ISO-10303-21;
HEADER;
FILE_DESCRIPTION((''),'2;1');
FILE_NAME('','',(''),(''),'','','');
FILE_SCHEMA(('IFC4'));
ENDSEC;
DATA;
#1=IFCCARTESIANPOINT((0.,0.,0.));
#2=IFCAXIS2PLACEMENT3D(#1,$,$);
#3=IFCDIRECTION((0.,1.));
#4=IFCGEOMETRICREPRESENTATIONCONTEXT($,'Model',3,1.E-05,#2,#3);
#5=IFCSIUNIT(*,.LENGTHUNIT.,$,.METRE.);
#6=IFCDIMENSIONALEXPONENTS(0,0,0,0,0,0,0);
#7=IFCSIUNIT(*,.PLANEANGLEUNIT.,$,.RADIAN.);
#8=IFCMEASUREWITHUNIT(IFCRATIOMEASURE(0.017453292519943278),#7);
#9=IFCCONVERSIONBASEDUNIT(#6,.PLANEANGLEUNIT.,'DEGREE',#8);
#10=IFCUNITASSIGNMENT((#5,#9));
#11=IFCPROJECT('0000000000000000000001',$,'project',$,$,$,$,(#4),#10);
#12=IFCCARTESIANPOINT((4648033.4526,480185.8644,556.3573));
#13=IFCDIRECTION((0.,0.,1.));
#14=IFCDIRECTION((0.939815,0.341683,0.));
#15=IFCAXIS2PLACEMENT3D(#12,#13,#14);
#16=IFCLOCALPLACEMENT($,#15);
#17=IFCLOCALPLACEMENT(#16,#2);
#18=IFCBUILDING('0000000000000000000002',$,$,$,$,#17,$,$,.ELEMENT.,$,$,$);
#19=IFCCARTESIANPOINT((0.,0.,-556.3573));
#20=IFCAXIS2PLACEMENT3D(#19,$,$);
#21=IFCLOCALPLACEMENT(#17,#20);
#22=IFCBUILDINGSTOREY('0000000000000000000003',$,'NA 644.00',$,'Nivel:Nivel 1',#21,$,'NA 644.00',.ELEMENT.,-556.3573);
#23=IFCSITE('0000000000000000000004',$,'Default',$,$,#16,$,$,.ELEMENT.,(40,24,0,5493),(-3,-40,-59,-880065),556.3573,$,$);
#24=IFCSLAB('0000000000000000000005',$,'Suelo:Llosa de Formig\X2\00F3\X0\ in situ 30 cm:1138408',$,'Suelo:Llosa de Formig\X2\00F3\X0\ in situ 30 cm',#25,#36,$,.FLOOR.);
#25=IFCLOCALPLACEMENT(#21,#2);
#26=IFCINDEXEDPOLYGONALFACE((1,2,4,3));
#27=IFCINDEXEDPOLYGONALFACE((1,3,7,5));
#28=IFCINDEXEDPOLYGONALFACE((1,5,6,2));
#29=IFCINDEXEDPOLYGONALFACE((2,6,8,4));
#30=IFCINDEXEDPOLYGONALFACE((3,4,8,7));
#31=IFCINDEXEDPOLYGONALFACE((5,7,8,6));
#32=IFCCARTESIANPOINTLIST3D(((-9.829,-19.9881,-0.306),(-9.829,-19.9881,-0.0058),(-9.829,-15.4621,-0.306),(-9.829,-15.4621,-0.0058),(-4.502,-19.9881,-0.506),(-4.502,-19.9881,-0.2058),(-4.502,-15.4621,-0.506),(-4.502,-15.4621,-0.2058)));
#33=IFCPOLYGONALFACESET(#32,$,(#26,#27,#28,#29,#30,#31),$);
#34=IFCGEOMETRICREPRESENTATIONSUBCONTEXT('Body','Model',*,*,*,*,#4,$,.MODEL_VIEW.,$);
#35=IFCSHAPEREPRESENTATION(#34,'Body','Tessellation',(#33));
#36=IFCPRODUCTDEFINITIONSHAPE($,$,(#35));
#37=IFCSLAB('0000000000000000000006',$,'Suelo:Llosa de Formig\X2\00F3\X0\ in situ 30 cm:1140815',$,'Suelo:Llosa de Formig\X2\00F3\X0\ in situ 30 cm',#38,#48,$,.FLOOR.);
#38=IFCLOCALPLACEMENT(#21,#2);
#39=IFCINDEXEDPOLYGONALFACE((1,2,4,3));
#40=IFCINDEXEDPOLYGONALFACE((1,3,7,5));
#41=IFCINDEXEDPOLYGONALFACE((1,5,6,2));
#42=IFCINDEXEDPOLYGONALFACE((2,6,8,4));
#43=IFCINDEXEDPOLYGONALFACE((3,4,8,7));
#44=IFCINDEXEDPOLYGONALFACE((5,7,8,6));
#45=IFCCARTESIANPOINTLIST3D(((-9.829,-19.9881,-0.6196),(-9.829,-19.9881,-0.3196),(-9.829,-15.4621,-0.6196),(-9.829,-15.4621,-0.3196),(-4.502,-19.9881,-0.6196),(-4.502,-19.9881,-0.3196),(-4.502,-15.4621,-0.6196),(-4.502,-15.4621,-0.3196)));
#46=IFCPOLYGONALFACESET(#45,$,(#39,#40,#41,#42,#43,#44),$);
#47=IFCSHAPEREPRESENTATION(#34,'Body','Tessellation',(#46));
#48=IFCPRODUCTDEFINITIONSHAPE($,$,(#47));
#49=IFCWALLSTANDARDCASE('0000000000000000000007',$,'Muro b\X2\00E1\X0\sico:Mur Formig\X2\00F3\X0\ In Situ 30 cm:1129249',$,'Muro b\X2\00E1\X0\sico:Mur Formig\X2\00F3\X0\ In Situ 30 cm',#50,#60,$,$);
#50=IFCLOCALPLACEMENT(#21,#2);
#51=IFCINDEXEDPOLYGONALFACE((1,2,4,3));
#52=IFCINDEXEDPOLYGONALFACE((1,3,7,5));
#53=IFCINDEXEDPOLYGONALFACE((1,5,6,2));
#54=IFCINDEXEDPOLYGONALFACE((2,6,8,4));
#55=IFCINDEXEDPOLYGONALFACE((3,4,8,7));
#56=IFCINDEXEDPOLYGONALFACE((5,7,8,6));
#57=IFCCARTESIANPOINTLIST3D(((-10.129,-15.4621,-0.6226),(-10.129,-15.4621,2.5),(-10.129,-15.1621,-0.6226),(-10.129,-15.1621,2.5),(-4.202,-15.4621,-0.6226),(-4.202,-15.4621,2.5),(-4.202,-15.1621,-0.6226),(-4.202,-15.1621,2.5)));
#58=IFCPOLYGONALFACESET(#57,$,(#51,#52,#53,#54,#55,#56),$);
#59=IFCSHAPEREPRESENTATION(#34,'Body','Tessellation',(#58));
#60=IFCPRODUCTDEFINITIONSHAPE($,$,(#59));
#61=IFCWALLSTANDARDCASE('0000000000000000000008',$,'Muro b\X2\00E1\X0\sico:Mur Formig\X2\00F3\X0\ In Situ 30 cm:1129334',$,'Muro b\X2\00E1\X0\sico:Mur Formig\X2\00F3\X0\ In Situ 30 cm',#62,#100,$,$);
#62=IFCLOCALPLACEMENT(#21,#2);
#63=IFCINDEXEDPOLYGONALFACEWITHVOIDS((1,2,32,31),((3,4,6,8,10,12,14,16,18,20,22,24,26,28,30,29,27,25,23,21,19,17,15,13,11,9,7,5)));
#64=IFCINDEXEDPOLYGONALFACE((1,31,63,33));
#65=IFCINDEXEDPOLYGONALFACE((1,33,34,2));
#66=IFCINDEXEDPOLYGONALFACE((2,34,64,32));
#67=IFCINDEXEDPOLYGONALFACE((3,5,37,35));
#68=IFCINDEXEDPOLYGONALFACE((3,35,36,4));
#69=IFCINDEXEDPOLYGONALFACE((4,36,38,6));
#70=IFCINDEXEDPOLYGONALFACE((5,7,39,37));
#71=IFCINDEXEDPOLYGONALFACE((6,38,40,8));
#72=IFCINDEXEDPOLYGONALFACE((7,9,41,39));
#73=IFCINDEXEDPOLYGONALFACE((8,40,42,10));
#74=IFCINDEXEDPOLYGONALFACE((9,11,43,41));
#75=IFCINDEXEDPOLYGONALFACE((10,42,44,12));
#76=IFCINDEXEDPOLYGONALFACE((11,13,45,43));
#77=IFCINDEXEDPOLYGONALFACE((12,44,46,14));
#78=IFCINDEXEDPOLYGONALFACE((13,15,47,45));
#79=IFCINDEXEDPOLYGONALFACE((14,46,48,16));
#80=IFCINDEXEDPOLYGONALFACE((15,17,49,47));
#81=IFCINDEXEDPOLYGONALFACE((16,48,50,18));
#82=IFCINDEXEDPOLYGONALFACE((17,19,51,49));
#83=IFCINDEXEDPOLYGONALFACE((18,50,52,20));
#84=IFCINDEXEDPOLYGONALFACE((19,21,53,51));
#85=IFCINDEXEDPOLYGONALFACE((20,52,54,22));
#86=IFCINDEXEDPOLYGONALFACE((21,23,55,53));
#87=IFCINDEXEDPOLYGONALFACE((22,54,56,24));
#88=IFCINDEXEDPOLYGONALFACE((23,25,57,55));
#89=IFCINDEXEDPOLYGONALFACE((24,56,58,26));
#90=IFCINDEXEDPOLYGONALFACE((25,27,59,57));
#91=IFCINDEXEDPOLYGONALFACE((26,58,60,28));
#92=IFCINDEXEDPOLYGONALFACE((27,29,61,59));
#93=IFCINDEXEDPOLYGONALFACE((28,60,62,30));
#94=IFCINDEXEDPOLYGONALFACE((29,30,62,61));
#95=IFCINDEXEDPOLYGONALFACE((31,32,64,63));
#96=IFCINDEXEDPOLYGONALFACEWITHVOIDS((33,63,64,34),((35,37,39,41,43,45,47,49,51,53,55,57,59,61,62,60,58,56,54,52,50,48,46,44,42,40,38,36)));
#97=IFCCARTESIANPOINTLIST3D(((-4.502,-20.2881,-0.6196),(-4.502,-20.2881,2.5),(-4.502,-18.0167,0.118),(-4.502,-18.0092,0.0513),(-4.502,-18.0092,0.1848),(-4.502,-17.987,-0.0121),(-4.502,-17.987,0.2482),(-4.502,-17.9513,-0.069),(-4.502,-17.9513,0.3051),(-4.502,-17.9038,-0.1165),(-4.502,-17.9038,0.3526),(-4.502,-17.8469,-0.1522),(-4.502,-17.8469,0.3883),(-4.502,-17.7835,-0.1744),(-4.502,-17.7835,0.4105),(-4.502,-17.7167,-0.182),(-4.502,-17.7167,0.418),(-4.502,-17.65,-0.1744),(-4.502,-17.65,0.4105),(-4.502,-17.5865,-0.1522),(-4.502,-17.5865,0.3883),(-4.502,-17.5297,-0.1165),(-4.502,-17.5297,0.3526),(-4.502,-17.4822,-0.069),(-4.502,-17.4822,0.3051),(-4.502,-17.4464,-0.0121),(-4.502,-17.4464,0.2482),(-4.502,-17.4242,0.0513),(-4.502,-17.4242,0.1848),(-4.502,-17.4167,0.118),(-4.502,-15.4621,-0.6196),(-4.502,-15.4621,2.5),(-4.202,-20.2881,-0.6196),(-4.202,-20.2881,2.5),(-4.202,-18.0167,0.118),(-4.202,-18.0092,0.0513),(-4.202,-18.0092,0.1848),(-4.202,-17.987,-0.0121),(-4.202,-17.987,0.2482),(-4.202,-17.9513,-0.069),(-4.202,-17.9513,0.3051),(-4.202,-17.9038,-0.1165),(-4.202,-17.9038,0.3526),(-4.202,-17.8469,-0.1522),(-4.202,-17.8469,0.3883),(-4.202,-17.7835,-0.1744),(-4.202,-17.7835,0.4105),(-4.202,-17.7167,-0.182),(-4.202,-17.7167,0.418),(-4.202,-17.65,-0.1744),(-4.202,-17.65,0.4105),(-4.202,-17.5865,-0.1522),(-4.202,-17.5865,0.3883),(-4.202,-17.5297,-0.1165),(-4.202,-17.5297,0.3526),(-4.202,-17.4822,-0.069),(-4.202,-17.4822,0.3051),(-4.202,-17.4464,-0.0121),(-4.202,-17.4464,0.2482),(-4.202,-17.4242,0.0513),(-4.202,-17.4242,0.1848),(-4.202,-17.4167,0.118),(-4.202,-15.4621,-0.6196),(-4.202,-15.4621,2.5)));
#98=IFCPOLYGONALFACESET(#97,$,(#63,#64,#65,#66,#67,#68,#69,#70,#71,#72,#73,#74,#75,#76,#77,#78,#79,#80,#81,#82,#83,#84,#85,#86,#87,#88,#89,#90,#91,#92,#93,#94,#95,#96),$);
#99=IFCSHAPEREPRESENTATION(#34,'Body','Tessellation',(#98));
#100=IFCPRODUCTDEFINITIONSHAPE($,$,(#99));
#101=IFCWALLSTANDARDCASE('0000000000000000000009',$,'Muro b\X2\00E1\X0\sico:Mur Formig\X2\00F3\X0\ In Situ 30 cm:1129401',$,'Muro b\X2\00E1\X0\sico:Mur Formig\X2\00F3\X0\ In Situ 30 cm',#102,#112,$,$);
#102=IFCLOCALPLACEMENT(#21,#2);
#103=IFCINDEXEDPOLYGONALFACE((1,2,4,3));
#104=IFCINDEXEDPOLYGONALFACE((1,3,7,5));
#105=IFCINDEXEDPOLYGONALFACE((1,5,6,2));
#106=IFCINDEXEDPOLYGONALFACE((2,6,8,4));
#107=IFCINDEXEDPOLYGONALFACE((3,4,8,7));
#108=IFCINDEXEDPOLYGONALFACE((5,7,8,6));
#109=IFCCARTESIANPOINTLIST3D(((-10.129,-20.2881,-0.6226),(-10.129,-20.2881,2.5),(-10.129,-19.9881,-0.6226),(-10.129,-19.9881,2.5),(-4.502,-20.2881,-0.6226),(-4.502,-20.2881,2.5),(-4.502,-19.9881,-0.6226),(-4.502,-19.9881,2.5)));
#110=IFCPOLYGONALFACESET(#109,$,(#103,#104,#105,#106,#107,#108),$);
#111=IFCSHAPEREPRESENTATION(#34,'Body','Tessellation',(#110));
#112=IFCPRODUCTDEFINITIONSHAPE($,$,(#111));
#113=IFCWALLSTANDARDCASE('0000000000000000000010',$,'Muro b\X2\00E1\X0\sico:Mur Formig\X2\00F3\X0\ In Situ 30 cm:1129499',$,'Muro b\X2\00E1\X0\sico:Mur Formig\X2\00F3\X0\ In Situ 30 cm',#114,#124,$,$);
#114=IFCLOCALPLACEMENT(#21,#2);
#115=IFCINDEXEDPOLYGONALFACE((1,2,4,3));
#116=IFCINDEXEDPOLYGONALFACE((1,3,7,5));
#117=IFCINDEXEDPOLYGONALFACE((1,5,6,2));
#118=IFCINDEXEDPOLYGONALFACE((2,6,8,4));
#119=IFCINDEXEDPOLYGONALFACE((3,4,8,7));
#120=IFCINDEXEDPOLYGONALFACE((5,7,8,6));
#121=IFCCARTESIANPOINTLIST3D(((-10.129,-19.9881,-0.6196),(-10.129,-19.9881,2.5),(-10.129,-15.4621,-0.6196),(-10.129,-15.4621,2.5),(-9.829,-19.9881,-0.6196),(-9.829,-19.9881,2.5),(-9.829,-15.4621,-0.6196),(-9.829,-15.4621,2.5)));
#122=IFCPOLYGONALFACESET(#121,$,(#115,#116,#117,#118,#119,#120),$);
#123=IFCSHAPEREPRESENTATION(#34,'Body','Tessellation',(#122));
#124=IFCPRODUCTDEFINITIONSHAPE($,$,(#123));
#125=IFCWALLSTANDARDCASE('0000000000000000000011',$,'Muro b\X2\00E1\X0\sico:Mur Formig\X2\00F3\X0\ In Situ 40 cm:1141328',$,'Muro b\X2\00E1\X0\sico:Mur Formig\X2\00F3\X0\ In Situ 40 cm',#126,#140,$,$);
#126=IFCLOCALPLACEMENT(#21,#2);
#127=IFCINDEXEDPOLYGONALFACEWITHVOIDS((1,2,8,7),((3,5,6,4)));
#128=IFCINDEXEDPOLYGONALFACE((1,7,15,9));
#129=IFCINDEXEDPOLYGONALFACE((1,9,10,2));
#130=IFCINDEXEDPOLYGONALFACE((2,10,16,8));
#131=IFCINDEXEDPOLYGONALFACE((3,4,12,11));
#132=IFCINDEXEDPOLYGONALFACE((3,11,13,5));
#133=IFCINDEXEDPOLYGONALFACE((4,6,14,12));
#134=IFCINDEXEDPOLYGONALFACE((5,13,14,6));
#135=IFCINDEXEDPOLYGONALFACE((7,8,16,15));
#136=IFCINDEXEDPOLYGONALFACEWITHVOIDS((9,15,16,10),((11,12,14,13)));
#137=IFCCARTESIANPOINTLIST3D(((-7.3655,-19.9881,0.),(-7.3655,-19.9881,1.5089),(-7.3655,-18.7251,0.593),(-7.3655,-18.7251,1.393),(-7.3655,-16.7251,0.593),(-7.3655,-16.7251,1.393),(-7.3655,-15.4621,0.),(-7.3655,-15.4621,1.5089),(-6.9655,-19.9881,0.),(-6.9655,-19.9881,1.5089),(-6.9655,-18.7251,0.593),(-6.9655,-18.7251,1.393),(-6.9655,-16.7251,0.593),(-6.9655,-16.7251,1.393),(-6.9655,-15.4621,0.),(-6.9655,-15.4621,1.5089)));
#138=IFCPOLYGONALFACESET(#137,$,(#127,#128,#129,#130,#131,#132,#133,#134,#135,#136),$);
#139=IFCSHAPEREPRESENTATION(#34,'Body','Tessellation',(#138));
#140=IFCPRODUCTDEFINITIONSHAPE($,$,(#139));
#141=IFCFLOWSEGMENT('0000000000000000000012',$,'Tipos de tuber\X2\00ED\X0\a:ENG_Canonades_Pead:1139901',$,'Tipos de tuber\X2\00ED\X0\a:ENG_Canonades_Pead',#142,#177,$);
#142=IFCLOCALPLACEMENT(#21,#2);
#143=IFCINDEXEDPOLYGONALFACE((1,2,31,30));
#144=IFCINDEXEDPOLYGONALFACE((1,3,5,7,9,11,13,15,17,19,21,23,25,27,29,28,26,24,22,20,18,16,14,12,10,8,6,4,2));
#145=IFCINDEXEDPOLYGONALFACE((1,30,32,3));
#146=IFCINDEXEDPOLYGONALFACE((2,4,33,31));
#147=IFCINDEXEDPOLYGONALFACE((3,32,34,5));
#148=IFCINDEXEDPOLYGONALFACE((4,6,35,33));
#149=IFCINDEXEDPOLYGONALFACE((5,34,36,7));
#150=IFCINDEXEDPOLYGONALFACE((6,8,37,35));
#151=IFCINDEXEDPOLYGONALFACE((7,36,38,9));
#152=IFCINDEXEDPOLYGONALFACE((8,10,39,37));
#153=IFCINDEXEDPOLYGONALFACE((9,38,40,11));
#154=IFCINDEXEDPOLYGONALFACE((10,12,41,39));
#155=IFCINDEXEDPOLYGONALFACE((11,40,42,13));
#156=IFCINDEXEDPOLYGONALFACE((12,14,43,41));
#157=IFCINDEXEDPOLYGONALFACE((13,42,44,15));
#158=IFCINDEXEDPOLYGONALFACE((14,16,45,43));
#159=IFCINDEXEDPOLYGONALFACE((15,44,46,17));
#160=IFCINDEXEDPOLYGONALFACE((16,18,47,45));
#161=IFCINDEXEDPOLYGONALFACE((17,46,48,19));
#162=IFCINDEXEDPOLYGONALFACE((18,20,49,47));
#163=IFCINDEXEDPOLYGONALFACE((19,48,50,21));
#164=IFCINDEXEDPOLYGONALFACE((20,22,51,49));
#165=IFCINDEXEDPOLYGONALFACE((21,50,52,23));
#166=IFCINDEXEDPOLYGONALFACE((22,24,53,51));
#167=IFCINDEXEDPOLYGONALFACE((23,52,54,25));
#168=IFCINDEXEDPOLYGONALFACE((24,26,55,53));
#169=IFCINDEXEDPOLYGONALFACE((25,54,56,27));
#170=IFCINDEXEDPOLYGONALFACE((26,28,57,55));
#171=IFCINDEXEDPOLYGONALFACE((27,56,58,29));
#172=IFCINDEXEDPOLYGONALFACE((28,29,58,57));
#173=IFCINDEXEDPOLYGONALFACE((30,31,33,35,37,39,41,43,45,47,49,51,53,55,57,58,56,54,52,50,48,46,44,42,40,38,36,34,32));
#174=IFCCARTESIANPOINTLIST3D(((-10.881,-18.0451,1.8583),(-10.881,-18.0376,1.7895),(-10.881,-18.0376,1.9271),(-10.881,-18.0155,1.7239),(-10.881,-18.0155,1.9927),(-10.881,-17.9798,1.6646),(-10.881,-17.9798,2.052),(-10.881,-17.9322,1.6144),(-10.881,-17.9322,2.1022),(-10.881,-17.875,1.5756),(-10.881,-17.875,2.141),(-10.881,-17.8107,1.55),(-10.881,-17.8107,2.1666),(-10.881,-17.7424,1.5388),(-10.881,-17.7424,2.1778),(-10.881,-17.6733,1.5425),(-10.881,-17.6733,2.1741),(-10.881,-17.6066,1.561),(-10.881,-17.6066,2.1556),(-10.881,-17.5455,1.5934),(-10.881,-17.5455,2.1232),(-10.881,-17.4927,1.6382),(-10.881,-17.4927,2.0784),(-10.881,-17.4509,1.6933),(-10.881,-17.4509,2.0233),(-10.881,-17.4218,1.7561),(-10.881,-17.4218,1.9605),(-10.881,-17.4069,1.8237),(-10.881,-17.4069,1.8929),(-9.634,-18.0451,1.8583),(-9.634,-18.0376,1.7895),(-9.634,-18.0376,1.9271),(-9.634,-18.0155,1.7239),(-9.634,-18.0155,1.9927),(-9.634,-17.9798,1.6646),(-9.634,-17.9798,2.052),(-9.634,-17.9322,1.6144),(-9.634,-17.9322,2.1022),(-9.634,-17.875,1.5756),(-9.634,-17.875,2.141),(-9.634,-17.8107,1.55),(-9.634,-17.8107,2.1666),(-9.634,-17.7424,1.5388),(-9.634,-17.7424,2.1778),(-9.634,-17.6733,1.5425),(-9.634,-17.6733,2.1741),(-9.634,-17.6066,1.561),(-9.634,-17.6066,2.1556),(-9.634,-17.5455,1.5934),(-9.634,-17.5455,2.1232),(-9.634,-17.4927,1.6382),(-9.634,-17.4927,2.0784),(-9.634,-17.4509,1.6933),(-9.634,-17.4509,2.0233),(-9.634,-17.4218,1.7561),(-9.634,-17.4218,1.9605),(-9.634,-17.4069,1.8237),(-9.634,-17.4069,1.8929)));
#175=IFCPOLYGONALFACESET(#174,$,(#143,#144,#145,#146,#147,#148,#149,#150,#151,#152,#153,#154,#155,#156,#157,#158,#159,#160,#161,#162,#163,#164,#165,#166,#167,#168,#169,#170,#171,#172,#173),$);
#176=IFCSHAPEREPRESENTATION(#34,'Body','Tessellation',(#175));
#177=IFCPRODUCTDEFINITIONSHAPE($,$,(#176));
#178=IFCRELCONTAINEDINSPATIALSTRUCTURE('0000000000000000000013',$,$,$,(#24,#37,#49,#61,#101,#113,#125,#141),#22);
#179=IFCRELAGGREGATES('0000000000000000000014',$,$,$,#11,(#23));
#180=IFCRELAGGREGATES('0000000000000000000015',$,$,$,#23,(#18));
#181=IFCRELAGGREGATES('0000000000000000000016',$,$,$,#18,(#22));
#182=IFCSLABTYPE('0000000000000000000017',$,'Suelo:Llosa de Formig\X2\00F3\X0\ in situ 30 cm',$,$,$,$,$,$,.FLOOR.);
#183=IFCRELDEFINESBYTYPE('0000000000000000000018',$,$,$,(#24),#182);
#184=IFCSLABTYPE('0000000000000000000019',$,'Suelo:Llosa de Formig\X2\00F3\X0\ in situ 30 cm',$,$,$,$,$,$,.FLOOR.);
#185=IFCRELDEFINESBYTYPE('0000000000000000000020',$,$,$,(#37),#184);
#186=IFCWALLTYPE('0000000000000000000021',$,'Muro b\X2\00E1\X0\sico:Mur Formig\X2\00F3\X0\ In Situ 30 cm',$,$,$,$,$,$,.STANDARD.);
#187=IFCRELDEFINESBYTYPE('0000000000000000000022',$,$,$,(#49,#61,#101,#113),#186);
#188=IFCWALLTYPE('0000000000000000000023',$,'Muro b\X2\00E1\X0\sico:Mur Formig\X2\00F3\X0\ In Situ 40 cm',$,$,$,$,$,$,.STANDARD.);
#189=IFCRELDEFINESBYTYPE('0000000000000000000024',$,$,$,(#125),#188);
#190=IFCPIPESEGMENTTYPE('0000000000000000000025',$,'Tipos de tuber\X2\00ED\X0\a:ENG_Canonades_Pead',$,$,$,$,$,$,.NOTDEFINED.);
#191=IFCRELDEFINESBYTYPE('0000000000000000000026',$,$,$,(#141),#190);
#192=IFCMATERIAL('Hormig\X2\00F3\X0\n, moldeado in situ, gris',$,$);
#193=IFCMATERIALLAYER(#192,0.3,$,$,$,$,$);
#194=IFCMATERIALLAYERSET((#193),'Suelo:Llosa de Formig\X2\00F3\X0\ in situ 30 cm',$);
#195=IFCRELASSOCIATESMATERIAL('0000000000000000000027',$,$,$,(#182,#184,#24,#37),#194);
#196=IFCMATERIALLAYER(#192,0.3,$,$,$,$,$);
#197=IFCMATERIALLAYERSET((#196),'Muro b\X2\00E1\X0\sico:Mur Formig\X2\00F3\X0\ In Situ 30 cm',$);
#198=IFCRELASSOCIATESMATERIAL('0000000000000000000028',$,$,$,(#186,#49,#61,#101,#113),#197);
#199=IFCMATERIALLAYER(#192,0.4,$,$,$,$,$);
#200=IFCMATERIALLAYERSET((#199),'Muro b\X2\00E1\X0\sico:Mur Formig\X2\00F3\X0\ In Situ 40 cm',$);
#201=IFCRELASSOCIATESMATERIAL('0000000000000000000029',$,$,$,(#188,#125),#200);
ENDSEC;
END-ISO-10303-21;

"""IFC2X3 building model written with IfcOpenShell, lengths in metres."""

from ifc_helpers import new_model, entity, si_unit, converted_unit, direction, frame, frame_2d, origin, origin_2d_with_axis, place, context, subcontext, project, spatial, rectangle, circle, extrude, clip, halfspace, material, layer, layer_set, layer_usage, type_object, element, save


model = new_model("IFC2X3")

# Units and contexts
model_context = context("Model", 3, precision=1e-05, world=origin(), true_north=direction((0.0, 1.0)))
body_context = subcontext(model_context, "Body", "Model", "MODEL_VIEW")
ifc_project = project(units=[si_unit("LENGTHUNIT", "METRE"), converted_unit("PLANEANGLEUNIT", "DEGREE", entity("IfcRatioMeasure", 0.017453292519943278), si_unit("PLANEANGLEUNIT", "RADIAN"), dimensions=[0, 0, 0, 0, 0, 0, 0])], contexts=[model_context])

# Site, building, storey
site_placement = place(None, frame((4648033.4526, 480185.8644, 556.3573), z_axis=(0.0, 0.0, 1.0), x_axis=(0.939815, 0.341683, 0.0)))
site = spatial("IfcSite", under=ifc_project, at=site_placement, Name="Default", CompositionType="ELEMENT", RefLatitude=(40, 24, 0, 5493), RefLongitude=(-3, -40, -59, -880065), RefElevation=556.3573)
building_placement = place(site_placement, origin())
building = spatial("IfcBuilding", under=site, at=building_placement, CompositionType="ELEMENT")
storey_placement = place(building_placement, frame((0.0, 0.0, -556.3573)))
storey = spatial("IfcBuildingStorey", under=building, at=storey_placement, Name="NA 644.00", ObjectType="Nivel:Nivel 1", LongName="NA 644.00", CompositionType="ELEMENT", Elevation=-556.3573)

# Slabs
ifc_material_1 = material(Name="Hormigón, moldeado in situ, gris")
ifc_layer_1 = layer(ifc_material_1, 0.3)
ifc_layer_set_1 = layer_set([ifc_layer_1], Name="Suelo:Llosa de Formigó in situ 30 cm")
ifc_layer_usage_1 = layer_usage(ifc_layer_set_1, "AXIS3", "POSITIVE", 0.0)
slab_type_1 = type_object("IfcSlabType", Name="Suelo:Llosa de Formigó in situ 30 cm", PredefinedType="FLOOR", material=ifc_layer_set_1)
slab_1_placement = place(storey_placement, origin())
element("IfcSlab", 1, at=slab_1_placement, inside=storey, type_object=slab_type_1, material=ifc_layer_usage_1, Name="Suelo:Llosa de Formigó in situ 30 cm:1138408", ObjectType="Suelo:Llosa de Formigó in situ 30 cm", PredefinedType="FLOOR", context=body_context, shape_type="SweptSolid", body=[
    clip(clip(extrude(rectangle(XDim=5.3308, YDim=4.526, at=frame_2d((0.0, 0.0), x_axis=(1.0, 0.0))), frame((-7.1655, -17.7251, -0.1058), z_axis=(-0.037518, 0.0, -0.999296), x_axis=(0.999296, 0.0, -0.037518)), (0.037518, 0.0, 0.999296), 0.3004), halfspace(frame((-9.829, -17.8301, -0.306), z_axis=(-0.037518, 0.0, -0.999296), x_axis=(0.999296, 0.0, -0.037518)), False)), halfspace(frame((-9.829, -17.8301, -0.0058), z_axis=(0.037518, 0.0, 0.999296), x_axis=(-0.999296, 0.0, 0.037518)), False)),
])
ifc_layer_usage_2 = layer_usage(ifc_layer_set_1, "AXIS3", "POSITIVE", 0.0)
slab_type_2 = type_object("IfcSlabType", Name="Suelo:Llosa de Formigó in situ 30 cm", PredefinedType="FLOOR", material=ifc_layer_set_1)
slab_2_placement = place(storey_placement, origin())
element("IfcSlab", 2, at=slab_2_placement, inside=storey, type_object=slab_type_2, material=ifc_layer_usage_2, Name="Suelo:Llosa de Formigó in situ 30 cm:1140815", ObjectType="Suelo:Llosa de Formigó in situ 30 cm", PredefinedType="FLOOR", context=body_context, shape_type="SweptSolid", body=[
    extrude(rectangle(XDim=4.526, YDim=5.327, at=frame_2d((0.0, 0.0), x_axis=(1.0, 0.0))), frame((-7.1655, -17.7251, -0.3196), z_axis=(0.0, 0.0, -1.0), x_axis=(0.0, 1.0, 0.0)), (0.0, 0.0, 1.0), 0.3),
])

# Wall
ifc_layer_2 = layer(ifc_material_1, 0.3)
ifc_layer_set_2 = layer_set([ifc_layer_2], Name="Muro básico:Mur Formigó In Situ 30 cm")
ifc_layer_usage_3 = layer_usage(ifc_layer_set_2, "AXIS2", "NEGATIVE", 0.15)
wall_type_1 = type_object("IfcWallType", Name="Muro básico:Mur Formigó In Situ 30 cm", PredefinedType="STANDARD", material=ifc_layer_set_2)
wall_1_placement = place(storey_placement, frame((-10.129, -15.3121, -0.6226)))
element("IfcWallStandardCase", 3, at=wall_1_placement, inside=storey, type_object=wall_type_1, material=ifc_layer_usage_3, Name="Muro básico:Mur Formigó In Situ 30 cm:1129249", ObjectType="Muro básico:Mur Formigó In Situ 30 cm", context=body_context, shape_type="SweptSolid", body=[
    extrude(rectangle(XDim=5.927, YDim=0.3, at=frame_2d((2.9635, 0.0), x_axis=(-1.0, 0.0))), origin(), (0.0, 0.0, 1.0), 3.1226),
])

# Wall, opening
ifc_layer_usage_4 = layer_usage(ifc_layer_set_2, "AXIS2", "NEGATIVE", 0.15)
wall_2_placement = place(storey_placement, frame((-4.352, -15.4621, -0.6196), z_axis=(0.0, 0.0, 1.0), x_axis=(0.0, -1.0, 0.0)))
wall_2 = element("IfcWallStandardCase", 4, at=wall_2_placement, inside=storey, type_object=wall_type_1, material=ifc_layer_usage_4, Name="Muro básico:Mur Formigó In Situ 30 cm:1129334", ObjectType="Muro básico:Mur Formigó In Situ 30 cm", context=body_context, shape_type="SweptSolid", body=[
    extrude(rectangle(XDim=4.826, YDim=0.3, at=frame_2d((2.413, 0.0), x_axis=(-1.0, 0.0))), origin(), (0.0, 0.0, 1.0), 3.1196),
])
opening_1_placement = place(wall_2_placement, origin())
element("IfcOpeningElement", 5, at=opening_1_placement, cuts=wall_2, ObjectType="Opening", context=body_context, shape_type="SweptSolid", body=[
    extrude(circle(Radius=0.3, at=origin_2d_with_axis()), frame((2.2546, 0.15, 0.7377), z_axis=(0.0, -1.0, 0.0), x_axis=(-1.0, 0.0, 0.0)), (0.0, 0.0, 1.0), 0.3),
])

# Walls
ifc_layer_usage_5 = layer_usage(ifc_layer_set_2, "AXIS2", "NEGATIVE", 0.15)
wall_3_placement = place(storey_placement, frame((-4.502, -20.1381, -0.6226), z_axis=(0.0, 0.0, 1.0), x_axis=(-1.0, 0.0, 0.0)))
element("IfcWallStandardCase", 6, at=wall_3_placement, inside=storey, type_object=wall_type_1, material=ifc_layer_usage_5, Name="Muro básico:Mur Formigó In Situ 30 cm:1129401", ObjectType="Muro básico:Mur Formigó In Situ 30 cm", context=body_context, shape_type="SweptSolid", body=[
    extrude(rectangle(XDim=5.627, YDim=0.3, at=frame_2d((2.8135, 0.0), x_axis=(-1.0, 0.0))), origin(), (0.0, 0.0, 1.0), 3.1226),
])
ifc_layer_usage_6 = layer_usage(ifc_layer_set_2, "AXIS2", "NEGATIVE", 0.15)
wall_4_placement = place(storey_placement, frame((-9.979, -19.9881, -0.6196), z_axis=(0.0, 0.0, 1.0), x_axis=(0.0, 1.0, 0.0)))
element("IfcWallStandardCase", 7, at=wall_4_placement, inside=storey, type_object=wall_type_1, material=ifc_layer_usage_6, Name="Muro básico:Mur Formigó In Situ 30 cm:1129499", ObjectType="Muro básico:Mur Formigó In Situ 30 cm", context=body_context, shape_type="SweptSolid", body=[
    extrude(rectangle(XDim=4.526, YDim=0.3, at=frame_2d((2.263, 0.0), x_axis=(-1.0, 0.0))), origin(), (0.0, 0.0, 1.0), 3.1196),
])

# Wall, opening
ifc_layer_3 = layer(ifc_material_1, 0.4)
ifc_layer_set_3 = layer_set([ifc_layer_3], Name="Muro básico:Mur Formigó In Situ 40 cm")
ifc_layer_usage_7 = layer_usage(ifc_layer_set_3, "AXIS2", "NEGATIVE", 0.2)
wall_type_2 = type_object("IfcWallType", Name="Muro básico:Mur Formigó In Situ 40 cm", PredefinedType="STANDARD", material=ifc_layer_set_3)
wall_5_placement = place(storey_placement, frame((-7.1655, -15.4621, 0.0), z_axis=(0.0, 0.0, 1.0), x_axis=(0.0, -1.0, 0.0)))
wall_5 = element("IfcWallStandardCase", 8, at=wall_5_placement, inside=storey, type_object=wall_type_2, material=ifc_layer_usage_7, Name="Muro básico:Mur Formigó In Situ 40 cm:1141328", ObjectType="Muro básico:Mur Formigó In Situ 40 cm", context=body_context, shape_type="SweptSolid", body=[
    extrude(rectangle(XDim=4.526, YDim=0.4, at=frame_2d((2.263, 0.0), x_axis=(-1.0, 0.0))), origin(), (0.0, 0.0, 1.0), 1.5089),
])
opening_2_placement = place(wall_5_placement, origin())
element("IfcOpeningElement", 9, at=opening_2_placement, cuts=wall_5, ObjectType="Opening", context=body_context, shape_type="SweptSolid", body=[
    extrude(rectangle(XDim=0.8, YDim=2.0, at=frame_2d((0.0, 0.0), x_axis=(1.0, 0.0))), frame((2.263, 0.2, 0.993), z_axis=(0.0, -1.0, 0.0), x_axis=(0.0, 0.0, -1.0)), (0.0, 0.0, 1.0), 0.4),
])

# Flow segment
pipe_segment_type = type_object("IfcPipeSegmentType", Name="Tipos de tubería:ENG_Canonades_Pead", PredefinedType="NOTDEFINED")
flow_segment_1_placement = place(storey_placement, origin())
element("IfcFlowSegment", 10, at=flow_segment_1_placement, inside=storey, type_object=pipe_segment_type, Name="Tipos de tubería:ENG_Canonades_Pead:1139901", ObjectType="Tipos de tubería:ENG_Canonades_Pead", context=body_context, shape_type="SweptSolid", body=[
    extrude(circle(Radius=0.32, at=origin_2d_with_axis()), frame((-10.881, -17.7251, 1.8583), z_axis=(1.0, 0.0, 0.0), x_axis=(0.0, -1.0, 0.0)), (0.0, 0.0, 1.0), 1.247),
])

save(model, "model.ifc")
